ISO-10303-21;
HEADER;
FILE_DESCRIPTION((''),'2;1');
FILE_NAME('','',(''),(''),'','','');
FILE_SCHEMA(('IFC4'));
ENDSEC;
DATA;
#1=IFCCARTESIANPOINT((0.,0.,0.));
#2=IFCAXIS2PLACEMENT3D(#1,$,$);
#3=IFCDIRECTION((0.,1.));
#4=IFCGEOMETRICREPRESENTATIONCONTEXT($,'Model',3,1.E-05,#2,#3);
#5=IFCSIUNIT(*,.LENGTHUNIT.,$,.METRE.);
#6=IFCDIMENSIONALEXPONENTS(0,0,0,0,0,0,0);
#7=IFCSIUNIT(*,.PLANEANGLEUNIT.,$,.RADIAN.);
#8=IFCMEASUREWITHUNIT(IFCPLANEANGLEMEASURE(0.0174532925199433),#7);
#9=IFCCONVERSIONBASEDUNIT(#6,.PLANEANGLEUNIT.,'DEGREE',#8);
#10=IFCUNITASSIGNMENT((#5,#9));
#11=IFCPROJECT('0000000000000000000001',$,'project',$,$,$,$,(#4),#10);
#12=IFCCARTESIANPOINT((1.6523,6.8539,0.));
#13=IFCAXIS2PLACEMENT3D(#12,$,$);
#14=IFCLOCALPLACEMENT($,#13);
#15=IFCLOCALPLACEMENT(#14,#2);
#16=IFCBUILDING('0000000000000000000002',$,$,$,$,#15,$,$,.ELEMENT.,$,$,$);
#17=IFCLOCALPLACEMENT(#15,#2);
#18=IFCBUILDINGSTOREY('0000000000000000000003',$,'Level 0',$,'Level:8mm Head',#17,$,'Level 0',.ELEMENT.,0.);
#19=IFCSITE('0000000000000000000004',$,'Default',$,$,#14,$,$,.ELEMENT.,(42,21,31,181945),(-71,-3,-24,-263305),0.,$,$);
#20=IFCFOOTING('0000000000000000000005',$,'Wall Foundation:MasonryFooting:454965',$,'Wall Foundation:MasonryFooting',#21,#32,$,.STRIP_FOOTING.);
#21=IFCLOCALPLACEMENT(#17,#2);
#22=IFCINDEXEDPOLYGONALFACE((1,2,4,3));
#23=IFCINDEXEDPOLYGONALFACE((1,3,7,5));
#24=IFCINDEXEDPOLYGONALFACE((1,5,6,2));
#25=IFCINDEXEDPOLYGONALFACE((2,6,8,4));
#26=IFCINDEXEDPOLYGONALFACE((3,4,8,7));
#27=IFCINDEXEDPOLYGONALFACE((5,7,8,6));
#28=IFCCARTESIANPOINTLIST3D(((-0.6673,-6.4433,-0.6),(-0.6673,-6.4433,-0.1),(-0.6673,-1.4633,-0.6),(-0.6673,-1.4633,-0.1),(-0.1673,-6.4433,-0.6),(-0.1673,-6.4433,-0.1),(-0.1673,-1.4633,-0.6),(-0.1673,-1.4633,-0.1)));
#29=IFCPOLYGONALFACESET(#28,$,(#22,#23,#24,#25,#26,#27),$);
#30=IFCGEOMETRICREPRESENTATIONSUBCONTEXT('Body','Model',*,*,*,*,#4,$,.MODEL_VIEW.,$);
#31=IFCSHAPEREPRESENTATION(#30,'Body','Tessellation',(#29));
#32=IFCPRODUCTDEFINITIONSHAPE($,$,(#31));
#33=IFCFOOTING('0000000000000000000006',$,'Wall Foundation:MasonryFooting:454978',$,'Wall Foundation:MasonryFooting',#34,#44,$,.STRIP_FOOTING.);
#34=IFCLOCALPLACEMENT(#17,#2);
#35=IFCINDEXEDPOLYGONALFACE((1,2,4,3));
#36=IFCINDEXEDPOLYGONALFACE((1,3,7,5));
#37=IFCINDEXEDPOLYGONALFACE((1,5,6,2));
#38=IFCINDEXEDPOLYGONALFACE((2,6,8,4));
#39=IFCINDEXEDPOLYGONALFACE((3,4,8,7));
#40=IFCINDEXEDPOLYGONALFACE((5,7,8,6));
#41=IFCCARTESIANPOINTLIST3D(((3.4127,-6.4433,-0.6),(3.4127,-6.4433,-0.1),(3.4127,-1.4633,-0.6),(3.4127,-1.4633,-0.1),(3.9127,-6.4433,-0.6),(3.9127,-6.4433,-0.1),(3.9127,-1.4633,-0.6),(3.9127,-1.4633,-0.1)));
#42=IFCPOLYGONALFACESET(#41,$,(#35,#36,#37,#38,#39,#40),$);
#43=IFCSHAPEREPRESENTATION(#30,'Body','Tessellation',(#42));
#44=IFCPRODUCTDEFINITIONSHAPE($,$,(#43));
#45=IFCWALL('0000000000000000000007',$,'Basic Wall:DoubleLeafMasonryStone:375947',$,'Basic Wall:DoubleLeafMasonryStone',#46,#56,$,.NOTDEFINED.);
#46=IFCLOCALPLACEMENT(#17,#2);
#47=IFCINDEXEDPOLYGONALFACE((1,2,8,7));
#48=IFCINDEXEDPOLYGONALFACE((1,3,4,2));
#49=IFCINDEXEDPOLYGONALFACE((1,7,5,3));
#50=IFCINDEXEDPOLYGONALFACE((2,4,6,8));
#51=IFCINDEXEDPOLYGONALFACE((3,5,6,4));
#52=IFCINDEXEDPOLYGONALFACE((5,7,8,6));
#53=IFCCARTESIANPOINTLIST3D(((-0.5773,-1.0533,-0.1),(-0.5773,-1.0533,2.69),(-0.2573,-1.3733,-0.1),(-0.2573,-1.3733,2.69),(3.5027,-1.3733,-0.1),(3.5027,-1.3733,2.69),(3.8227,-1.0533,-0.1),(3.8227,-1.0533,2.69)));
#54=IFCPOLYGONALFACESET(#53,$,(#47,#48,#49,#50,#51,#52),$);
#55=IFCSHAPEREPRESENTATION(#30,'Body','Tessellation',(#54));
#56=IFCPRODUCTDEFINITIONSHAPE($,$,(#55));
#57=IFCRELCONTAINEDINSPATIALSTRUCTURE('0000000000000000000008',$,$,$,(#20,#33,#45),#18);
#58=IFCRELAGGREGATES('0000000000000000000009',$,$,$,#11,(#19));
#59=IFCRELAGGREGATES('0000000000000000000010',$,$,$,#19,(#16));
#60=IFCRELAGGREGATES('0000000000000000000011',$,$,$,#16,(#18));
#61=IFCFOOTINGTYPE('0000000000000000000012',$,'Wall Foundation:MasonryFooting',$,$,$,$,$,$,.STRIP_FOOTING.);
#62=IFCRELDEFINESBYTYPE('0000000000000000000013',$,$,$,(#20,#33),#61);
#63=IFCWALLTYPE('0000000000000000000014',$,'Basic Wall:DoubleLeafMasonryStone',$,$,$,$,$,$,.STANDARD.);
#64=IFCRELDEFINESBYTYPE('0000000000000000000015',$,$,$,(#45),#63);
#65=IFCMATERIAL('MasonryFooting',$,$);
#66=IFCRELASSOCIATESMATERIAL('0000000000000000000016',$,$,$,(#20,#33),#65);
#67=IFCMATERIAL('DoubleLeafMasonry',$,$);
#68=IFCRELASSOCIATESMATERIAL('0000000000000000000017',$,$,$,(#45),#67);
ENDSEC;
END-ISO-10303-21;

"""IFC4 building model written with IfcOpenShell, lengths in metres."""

from ifc_helpers import new_model, entity, si_unit, converted_unit, direction, frame, origin, place, context, subcontext, project, spatial, indexed_curve, outline, extrude, material, type_object, element, save


model = new_model("IFC4")

# Units and contexts
model_context = context("Model", 3, precision=1e-05, world=origin(), true_north=direction((0.0, 1.0)))
body_context = subcontext(model_context, "Body", "Model", "MODEL_VIEW")
ifc_project = project(units=[si_unit("LENGTHUNIT", "METRE"), converted_unit("PLANEANGLEUNIT", "DEGREE", entity("IfcPlaneAngleMeasure", 0.0174532925199433), si_unit("PLANEANGLEUNIT", "RADIAN"), dimensions=[0, 0, 0, 0, 0, 0, 0])], contexts=[model_context])

# Site, building, storey
site_placement = place(None, frame((1.6523, 6.8539, 0.0)))
site = spatial("IfcSite", under=ifc_project, at=site_placement, Name="Default", CompositionType="ELEMENT", RefLatitude=(42, 21, 31, 181945), RefLongitude=(-71, -3, -24, -263305), RefElevation=0.0)
building_placement = place(site_placement, origin())
building = spatial("IfcBuilding", under=site, at=building_placement, CompositionType="ELEMENT")
storey_placement = place(building_placement, origin())
storey = spatial("IfcBuildingStorey", under=building, at=storey_placement, Name="Level 0", ObjectType="Level:8mm Head", LongName="Level 0", CompositionType="ELEMENT", Elevation=0.0)

# Footings
ifc_material_1 = material(Name="MasonryFooting")
footing_type = type_object("IfcFootingType", Name="Wall Foundation:MasonryFooting", PredefinedType="STRIP_FOOTING")
footing_1_placement = place(storey_placement, origin())
element("IfcFooting", 1, at=footing_1_placement, inside=storey, type_object=footing_type, material=ifc_material_1, Name="Wall Foundation:MasonryFooting:454965", ObjectType="Wall Foundation:MasonryFooting", PredefinedType="STRIP_FOOTING", context=body_context, shape_type="SweptSolid", body=[
    extrude(outline(indexed_curve([(-2.49, -0.25), (2.49, -0.25), (2.49, 0.25), (-2.49, 0.25), (-2.49, -0.25)], self_intersect=False)), frame((-0.4173, -3.9533, -0.6), z_axis=(0.0, 0.0, 1.0), x_axis=(0.0, 1.0, 0.0)), (0.0, 0.0, 1.0), 0.5),
])
footing_2_placement = place(storey_placement, origin())
element("IfcFooting", 2, at=footing_2_placement, inside=storey, type_object=footing_type, material=ifc_material_1, Name="Wall Foundation:MasonryFooting:454978", ObjectType="Wall Foundation:MasonryFooting", PredefinedType="STRIP_FOOTING", context=body_context, shape_type="SweptSolid", body=[
    extrude(outline(indexed_curve([(-2.49, -0.25), (2.49, -0.25), (2.49, 0.25), (-2.49, 0.25), (-2.49, -0.25)], self_intersect=False)), frame((3.6627, -3.9533, -0.6), z_axis=(0.0, 0.0, 1.0), x_axis=(0.0, 1.0, 0.0)), (0.0, 0.0, 1.0), 0.5),
])

# Wall
ifc_material_2 = material(Name="DoubleLeafMasonry")
wall_type = type_object("IfcWallType", Name="Basic Wall:DoubleLeafMasonryStone", PredefinedType="STANDARD")
wall_placement = place(storey_placement, frame((-0.5773, -1.2133, -0.1)))
element("IfcWall", 3, at=wall_placement, inside=storey, type_object=wall_type, material=ifc_material_2, Name="Basic Wall:DoubleLeafMasonryStone:375947", ObjectType="Basic Wall:DoubleLeafMasonryStone", PredefinedType="NOTDEFINED", context=body_context, shape_type="SweptSolid", body=[
    extrude(outline(indexed_curve([(4.08, -0.16), (4.4, 0.16), (0.0, 0.16), (0.32, -0.16), (4.08, -0.16)], self_intersect=False)), origin(), (0.0, 0.0, 1.0), 2.79),
])

save(model, "model.ifc")
